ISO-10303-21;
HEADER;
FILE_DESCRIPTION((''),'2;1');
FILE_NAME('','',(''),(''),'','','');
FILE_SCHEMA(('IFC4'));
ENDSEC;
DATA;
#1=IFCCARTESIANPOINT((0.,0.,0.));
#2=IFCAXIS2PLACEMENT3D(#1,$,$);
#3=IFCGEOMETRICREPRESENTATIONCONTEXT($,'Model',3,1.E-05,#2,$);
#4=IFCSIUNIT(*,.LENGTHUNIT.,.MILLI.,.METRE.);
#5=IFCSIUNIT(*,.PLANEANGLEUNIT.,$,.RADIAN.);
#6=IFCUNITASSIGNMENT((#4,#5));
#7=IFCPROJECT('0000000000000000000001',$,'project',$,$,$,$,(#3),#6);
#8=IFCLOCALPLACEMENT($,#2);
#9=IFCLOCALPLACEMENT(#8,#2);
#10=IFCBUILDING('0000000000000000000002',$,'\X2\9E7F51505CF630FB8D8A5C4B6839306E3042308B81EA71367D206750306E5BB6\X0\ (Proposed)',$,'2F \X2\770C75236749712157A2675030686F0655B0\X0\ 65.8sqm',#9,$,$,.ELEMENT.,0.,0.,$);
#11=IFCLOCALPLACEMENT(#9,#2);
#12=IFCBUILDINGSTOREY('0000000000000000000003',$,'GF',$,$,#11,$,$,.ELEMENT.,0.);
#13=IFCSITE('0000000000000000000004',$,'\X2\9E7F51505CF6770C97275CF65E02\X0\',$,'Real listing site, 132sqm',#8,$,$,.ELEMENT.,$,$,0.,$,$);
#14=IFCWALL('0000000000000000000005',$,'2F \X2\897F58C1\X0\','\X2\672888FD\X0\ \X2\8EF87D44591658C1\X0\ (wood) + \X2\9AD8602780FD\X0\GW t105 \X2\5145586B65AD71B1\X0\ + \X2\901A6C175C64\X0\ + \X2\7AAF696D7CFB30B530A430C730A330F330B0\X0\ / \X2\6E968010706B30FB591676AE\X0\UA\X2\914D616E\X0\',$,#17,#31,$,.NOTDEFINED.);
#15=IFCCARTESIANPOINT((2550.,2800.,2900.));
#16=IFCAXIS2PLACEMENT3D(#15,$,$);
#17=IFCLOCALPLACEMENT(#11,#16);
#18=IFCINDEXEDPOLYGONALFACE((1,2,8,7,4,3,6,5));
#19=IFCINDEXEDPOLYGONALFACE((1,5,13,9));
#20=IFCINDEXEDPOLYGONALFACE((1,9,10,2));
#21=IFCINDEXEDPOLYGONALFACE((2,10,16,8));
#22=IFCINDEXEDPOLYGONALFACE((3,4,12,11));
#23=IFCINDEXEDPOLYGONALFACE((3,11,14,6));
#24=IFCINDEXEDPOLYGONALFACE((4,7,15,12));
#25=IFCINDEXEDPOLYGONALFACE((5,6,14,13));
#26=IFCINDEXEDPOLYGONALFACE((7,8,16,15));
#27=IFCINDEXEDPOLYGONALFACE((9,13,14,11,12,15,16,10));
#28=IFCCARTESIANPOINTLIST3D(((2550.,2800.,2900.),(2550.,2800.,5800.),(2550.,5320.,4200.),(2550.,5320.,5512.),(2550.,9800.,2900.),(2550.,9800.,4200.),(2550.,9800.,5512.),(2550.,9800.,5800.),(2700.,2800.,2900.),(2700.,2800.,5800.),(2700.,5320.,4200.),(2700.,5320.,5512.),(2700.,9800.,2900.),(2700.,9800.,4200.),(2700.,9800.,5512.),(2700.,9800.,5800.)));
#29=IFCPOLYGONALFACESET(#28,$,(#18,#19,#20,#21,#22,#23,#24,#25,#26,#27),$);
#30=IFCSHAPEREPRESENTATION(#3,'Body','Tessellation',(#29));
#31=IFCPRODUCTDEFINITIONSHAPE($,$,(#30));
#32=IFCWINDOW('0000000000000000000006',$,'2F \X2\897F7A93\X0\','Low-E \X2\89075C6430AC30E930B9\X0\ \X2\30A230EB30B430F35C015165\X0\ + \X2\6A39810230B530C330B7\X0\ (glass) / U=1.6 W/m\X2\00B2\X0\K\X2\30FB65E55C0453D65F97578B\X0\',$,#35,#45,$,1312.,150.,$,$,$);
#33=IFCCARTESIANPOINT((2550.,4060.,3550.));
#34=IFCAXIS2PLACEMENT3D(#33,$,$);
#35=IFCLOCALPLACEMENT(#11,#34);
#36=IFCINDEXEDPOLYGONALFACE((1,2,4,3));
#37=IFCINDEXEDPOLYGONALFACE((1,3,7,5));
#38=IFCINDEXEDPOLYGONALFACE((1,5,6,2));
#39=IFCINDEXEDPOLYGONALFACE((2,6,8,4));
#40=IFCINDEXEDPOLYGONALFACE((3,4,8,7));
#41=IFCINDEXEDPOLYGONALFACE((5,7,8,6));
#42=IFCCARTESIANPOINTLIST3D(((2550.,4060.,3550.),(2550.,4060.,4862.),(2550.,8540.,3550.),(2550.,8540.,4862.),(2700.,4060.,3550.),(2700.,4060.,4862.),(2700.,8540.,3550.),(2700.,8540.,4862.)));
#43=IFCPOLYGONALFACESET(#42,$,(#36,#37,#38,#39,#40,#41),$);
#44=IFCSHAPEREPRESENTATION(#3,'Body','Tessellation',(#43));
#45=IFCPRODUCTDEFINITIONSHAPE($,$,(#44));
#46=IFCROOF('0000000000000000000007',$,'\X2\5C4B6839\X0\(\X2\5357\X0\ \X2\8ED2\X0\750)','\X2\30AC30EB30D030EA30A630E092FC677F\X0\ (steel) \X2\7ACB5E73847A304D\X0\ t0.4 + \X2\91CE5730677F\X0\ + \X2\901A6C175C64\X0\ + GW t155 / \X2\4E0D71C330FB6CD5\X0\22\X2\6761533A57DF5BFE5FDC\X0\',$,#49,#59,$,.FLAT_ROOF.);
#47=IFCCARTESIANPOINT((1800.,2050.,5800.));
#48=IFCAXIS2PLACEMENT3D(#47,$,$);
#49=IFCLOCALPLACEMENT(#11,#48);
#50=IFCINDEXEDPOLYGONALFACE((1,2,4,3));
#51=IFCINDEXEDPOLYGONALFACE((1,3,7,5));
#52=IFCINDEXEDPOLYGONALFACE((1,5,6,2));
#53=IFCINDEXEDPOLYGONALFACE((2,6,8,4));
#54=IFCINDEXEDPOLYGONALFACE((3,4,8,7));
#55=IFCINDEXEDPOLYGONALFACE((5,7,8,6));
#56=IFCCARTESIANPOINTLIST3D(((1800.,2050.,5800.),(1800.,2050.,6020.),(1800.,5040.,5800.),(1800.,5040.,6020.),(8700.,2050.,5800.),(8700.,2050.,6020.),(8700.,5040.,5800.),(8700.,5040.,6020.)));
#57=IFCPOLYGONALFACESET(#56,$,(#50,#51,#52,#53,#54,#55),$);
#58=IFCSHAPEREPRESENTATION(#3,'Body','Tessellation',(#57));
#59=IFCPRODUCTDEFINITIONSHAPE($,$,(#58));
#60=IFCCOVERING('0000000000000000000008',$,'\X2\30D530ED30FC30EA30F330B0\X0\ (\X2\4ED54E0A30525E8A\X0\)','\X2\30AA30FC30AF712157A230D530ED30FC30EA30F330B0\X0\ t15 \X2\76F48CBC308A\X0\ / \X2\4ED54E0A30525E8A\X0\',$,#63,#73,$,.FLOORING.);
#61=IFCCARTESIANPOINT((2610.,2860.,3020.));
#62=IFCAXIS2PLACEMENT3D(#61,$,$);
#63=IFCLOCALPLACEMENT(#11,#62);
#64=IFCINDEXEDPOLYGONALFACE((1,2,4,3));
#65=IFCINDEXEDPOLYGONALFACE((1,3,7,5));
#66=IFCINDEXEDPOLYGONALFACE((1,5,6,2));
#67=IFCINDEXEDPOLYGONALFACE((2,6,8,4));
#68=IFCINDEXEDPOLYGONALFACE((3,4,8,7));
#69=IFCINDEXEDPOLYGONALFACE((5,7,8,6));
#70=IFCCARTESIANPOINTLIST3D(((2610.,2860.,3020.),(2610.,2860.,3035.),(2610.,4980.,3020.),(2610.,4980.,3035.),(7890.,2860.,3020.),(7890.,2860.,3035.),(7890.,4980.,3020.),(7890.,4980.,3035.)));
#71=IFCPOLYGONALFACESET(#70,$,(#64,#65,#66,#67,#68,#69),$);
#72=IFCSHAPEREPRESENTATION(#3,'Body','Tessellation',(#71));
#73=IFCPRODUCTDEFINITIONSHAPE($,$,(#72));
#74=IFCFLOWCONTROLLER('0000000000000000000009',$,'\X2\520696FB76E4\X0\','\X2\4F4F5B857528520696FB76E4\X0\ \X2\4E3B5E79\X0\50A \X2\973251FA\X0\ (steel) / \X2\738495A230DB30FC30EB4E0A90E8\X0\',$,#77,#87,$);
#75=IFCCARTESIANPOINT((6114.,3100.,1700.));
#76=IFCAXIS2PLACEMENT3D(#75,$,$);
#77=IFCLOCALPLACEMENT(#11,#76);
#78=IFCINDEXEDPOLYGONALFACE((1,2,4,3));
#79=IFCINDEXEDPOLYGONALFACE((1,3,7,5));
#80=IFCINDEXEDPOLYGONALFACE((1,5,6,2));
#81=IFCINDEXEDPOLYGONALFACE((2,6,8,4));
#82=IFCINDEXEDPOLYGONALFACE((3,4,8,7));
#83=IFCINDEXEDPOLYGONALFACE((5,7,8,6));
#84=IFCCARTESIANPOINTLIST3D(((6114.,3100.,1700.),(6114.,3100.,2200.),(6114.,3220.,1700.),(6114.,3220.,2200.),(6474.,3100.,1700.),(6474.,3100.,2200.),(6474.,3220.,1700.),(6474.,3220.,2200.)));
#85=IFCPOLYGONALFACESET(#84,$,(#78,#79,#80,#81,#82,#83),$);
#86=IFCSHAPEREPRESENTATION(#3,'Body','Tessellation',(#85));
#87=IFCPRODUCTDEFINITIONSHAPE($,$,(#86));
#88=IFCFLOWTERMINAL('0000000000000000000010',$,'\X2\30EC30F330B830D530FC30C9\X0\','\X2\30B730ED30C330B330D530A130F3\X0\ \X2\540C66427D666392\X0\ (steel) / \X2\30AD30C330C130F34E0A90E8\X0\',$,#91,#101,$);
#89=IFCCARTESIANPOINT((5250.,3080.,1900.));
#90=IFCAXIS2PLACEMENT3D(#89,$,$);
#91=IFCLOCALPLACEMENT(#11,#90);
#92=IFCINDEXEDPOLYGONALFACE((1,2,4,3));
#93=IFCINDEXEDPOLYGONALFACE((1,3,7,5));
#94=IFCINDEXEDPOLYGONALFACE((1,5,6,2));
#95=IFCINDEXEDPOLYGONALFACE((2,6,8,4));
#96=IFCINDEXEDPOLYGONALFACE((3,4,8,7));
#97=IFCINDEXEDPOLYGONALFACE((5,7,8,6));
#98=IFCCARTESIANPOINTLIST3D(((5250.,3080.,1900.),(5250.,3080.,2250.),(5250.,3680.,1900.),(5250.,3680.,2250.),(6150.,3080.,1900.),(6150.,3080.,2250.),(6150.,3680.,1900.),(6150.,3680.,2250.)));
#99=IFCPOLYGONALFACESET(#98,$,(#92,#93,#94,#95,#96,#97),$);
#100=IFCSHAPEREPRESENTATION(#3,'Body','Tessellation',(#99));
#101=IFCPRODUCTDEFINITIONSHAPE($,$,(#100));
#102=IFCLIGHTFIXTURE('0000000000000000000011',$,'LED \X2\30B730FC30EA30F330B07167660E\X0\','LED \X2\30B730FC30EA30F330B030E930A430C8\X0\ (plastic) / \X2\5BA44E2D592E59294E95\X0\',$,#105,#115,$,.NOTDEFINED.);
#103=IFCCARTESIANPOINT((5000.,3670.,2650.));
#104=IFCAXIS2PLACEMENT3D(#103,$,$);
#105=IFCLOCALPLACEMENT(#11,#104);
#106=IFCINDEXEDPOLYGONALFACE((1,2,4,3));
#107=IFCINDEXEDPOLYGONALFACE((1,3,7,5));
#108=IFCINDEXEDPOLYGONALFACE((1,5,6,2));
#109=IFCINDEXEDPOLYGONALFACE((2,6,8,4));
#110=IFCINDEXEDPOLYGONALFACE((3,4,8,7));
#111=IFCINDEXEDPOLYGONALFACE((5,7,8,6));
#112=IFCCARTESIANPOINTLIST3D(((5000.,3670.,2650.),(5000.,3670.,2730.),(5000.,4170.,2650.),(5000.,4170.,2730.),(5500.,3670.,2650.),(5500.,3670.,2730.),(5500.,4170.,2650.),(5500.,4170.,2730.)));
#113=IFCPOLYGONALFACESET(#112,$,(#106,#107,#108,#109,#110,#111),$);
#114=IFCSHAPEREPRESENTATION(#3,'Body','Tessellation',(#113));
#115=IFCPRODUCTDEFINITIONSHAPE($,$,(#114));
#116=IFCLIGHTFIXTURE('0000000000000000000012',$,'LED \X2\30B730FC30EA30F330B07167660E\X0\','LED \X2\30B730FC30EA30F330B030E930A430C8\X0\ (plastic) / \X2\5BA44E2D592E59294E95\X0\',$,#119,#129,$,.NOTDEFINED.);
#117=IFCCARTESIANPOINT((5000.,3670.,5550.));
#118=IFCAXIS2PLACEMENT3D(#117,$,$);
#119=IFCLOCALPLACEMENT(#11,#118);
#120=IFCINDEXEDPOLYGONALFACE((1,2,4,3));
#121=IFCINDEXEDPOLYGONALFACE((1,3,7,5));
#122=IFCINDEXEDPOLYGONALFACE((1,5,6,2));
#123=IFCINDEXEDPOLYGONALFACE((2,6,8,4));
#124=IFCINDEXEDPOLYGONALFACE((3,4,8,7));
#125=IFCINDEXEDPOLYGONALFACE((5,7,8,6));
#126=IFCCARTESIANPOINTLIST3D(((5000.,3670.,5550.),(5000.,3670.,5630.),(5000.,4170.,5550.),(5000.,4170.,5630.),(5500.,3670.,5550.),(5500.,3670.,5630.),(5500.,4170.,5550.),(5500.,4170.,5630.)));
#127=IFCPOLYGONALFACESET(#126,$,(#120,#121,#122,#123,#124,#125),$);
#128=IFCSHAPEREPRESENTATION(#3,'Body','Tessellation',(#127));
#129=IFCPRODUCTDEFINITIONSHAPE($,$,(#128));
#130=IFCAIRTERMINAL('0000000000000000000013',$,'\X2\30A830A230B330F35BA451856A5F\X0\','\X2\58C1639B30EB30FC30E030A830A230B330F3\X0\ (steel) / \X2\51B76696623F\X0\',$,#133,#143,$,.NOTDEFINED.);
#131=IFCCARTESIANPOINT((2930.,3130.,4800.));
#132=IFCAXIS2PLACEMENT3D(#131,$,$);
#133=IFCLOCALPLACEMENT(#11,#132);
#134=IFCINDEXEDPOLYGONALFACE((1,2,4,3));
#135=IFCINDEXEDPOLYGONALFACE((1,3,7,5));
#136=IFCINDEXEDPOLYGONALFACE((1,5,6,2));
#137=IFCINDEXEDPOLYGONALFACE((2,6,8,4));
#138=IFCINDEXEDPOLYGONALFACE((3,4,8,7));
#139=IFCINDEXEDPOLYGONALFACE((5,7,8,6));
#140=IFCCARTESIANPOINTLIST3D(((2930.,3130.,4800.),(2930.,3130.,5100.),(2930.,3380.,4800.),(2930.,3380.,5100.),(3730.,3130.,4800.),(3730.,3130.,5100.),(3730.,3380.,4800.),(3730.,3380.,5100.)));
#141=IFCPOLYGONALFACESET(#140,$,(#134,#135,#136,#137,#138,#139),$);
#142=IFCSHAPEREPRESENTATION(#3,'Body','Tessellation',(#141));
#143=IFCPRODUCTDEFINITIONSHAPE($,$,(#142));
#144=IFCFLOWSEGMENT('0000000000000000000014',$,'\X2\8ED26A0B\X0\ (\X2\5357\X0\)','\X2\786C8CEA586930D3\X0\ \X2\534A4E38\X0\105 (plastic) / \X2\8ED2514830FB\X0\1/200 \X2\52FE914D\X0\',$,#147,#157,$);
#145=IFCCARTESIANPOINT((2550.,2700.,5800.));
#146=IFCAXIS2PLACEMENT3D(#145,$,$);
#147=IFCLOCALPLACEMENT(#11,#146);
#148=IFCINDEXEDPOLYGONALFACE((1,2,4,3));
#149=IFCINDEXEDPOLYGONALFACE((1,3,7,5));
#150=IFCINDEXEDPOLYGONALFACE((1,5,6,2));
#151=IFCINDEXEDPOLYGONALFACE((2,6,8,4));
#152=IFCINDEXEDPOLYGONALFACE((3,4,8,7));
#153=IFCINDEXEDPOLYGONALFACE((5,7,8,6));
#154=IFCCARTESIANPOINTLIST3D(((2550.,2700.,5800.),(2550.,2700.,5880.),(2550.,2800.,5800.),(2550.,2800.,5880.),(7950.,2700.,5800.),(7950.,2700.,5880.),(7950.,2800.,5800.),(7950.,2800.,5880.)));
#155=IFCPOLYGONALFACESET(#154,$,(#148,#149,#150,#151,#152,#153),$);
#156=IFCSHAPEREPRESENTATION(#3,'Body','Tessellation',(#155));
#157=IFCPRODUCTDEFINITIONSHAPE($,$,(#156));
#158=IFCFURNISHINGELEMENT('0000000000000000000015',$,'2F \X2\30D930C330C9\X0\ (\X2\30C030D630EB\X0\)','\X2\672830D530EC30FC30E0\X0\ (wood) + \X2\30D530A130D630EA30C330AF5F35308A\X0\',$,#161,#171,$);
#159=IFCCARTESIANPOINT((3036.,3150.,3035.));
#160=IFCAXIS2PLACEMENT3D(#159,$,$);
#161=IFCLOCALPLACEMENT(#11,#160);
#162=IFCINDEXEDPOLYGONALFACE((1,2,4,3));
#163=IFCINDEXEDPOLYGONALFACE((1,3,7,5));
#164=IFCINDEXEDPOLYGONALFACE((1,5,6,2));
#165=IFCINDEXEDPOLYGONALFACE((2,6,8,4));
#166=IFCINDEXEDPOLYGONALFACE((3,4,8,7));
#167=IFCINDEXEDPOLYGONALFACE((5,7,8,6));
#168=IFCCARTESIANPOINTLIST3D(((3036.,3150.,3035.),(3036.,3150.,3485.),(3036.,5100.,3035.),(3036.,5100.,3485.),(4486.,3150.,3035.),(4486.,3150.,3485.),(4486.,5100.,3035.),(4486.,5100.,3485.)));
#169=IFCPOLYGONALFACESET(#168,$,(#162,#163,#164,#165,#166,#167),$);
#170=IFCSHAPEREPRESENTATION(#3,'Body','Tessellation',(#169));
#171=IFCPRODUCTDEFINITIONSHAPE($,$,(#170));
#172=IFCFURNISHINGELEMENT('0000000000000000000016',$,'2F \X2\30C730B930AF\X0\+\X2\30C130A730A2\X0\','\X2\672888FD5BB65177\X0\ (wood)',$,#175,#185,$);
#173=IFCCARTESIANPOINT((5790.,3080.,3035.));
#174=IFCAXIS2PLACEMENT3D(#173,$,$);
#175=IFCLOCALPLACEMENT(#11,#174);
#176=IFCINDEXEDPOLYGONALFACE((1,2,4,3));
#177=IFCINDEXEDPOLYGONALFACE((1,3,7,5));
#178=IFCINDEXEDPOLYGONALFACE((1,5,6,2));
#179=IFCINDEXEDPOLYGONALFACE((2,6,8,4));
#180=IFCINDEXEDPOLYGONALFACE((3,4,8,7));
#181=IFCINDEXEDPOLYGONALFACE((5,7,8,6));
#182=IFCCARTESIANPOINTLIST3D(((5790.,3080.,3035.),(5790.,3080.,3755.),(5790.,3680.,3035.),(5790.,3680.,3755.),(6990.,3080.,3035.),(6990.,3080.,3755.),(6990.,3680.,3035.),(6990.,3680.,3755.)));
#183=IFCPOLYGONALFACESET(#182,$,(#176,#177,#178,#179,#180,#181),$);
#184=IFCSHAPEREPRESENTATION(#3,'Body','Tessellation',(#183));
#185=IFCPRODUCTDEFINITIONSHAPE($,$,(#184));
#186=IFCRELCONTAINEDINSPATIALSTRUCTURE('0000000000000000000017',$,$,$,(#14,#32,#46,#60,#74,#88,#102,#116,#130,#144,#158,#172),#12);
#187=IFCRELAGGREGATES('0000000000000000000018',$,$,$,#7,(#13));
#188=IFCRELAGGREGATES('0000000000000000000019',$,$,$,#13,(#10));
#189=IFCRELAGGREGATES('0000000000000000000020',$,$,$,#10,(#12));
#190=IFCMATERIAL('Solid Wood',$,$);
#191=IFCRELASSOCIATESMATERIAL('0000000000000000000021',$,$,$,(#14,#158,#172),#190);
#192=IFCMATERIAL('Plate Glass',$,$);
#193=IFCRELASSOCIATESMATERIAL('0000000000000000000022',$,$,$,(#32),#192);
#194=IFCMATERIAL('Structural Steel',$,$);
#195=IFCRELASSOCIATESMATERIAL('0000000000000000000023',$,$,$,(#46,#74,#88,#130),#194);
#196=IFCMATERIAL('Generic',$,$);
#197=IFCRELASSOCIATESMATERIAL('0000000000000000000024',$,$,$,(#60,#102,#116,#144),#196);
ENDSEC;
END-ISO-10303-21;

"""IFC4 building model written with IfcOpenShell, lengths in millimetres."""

from ifc_helpers import new_model, si_unit, frame, frame_2d, origin, place, context, project, spatial, rectangle, extrude, material, element, fill, save


model = new_model("IFC4")

# Units and contexts
model_context = context("Model", 3, precision=1e-05, world=origin())
ifc_project = project(units=[si_unit("LENGTHUNIT", "METRE", prefix="MILLI"), si_unit("PLANEANGLEUNIT", "RADIAN")], contexts=[model_context])

# Site, building, storey
site_placement = place(None, origin())
site = spatial("IfcSite", under=ifc_project, at=site_placement, Name="鹿児島県霧島市", ObjectType="Real listing site, 132sqm", CompositionType="ELEMENT", RefElevation=0.0)
building_placement = place(site_placement, origin())
building = spatial("IfcBuilding", under=site, at=building_placement, Name="鹿児島・越屋根のある自然素材の家 (Proposed)", ObjectType="2F 県産杉無垢材と漆喰 65.8sqm", CompositionType="ELEMENT", ElevationOfRefHeight=0.0, ElevationOfTerrain=0.0)
storey_placement = place(building_placement, origin())
storey = spatial("IfcBuildingStorey", under=building, at=storey_placement, Name="GF", CompositionType="ELEMENT", Elevation=0.0)

# Shared definitions
ifc_material_1 = material(Name="Solid Wood")

# Wall, opening, window
ifc_material_2 = material(Name="Plate Glass")
wall_1_placement = place(storey_placement, frame((2550.0, 2800.0, 2900.0)))
wall_1 = element("IfcWall", 1, at=wall_1_placement, inside=storey, material=ifc_material_1, Name="2F 西壁", Description="木製 軸組外壁 (wood) + 高性能GW t105 充填断熱 + 通気層 + 窯業系サイディング / 準耐火・外皮UA配慮", PredefinedType="NOTDEFINED", context=model_context, shape_type="SweptSolid", body=[
    extrude(rectangle(XDim=150.0, YDim=7000.0, at=frame_2d((75.0, 3500.0))), frame((2550.0, 2800.0, 2900.0)), (0.0, 0.0, 1.0), 2900.0),
])
opening_1_placement = place(storey_placement, frame((2550.0, 4060.0, 3550.0)))
opening_1 = element("IfcOpeningElement", 2, at=opening_1_placement, cuts=wall_1, PredefinedType="NOTDEFINED", context=model_context, shape_type="SweptSolid", body=[
    extrude(rectangle(XDim=150.0, YDim=4480.0, at=frame_2d((75.0, 2240.0))), frame((2550.0, 4060.0, 3550.0)), (0.0, 0.0, 1.0), 1312.0),
])
window_1_placement = place(storey_placement, frame((2550.0, 4060.0, 3550.0)))
window_1 = element("IfcWindow", 3, at=window_1_placement, inside=storey, material=ifc_material_2, Name="2F 西窓", Description="Low-E 複層ガラス アルゴン封入 + 樹脂サッシ (glass) / U=1.6 W/m²K・日射取得型", OverallHeight=1312.0, OverallWidth=150.0, context=model_context, shape_type="SweptSolid", body=[
    extrude(rectangle(XDim=150.0, YDim=4480.0, at=frame_2d((75.0, 2240.0))), frame((2550.0, 4060.0, 3550.0)), (0.0, 0.0, 1.0), 1312.0),
])
fill(opening_1, window_1)

# Roof
ifc_material_3 = material(Name="Structural Steel")
for number, where, name in (
    (4, (1800.0, 2050.0, 5800.0), "屋根(南 軒750)"),
):
    element("IfcRoof", number, at=place(storey_placement, frame(where)), inside=storey, material=ifc_material_3, Name=name, Description="ガルバリウム鋼板 (steel) 立平葺き t0.4 + 野地板 + 通気層 + GW t155 / 不燃・法22条区域対応", PredefinedType="FLAT_ROOF", context=model_context, shape_type="SweptSolid", body=[
        extrude(rectangle(XDim=6900.0, YDim=2990.0, at=frame_2d((3450.0, 1495.0))), frame((1800.0, 2050.0, 5800.0)), (0.0, 0.0, 1.0), 220.0),
    ])

# Covering
ifc_material_4 = material(Name="Generic")
covering_placement = place(storey_placement, frame((2610.0, 2860.0, 3020.0)))
element("IfcCovering", 5, at=covering_placement, inside=storey, material=ifc_material_4, Name="フローリング (仕上げ床)", Description="オーク無垢フローリング t15 直貼り / 仕上げ床", PredefinedType="FLOORING", context=model_context, shape_type="SweptSolid", body=[
    extrude(rectangle(XDim=5280.0, YDim=2120.0, at=frame_2d((2640.0, 1060.0))), frame((2610.0, 2860.0, 3020.0)), (0.0, 0.0, 1.0), 15.0),
])

# Flow controller
flow_controller_placement = place(storey_placement, frame((6114.0, 3100.0, 1700.0)))
element("IfcFlowController", 6, at=flow_controller_placement, inside=storey, material=ifc_material_3, Name="分電盤", Description="住宅用分電盤 主幹50A 露出 (steel) / 玄関ホール上部", context=model_context, shape_type="SweptSolid", body=[
    extrude(rectangle(XDim=360.0, YDim=120.0, at=frame_2d((180.0, 60.0))), frame((6114.0, 3100.0, 1700.0)), (0.0, 0.0, 1.0), 500.0),
])

# Flow terminal
flow_terminal_placement = place(storey_placement, frame((5250.0, 3080.0, 1900.0)))
element("IfcFlowTerminal", 7, at=flow_terminal_placement, inside=storey, material=ifc_material_3, Name="レンジフード", Description="シロッコファン 同時給排 (steel) / キッチン上部", context=model_context, shape_type="SweptSolid", body=[
    extrude(rectangle(XDim=900.0, YDim=600.0, at=frame_2d((450.0, 300.0))), frame((5250.0, 3080.0, 1900.0)), (0.0, 0.0, 1.0), 350.0),
])

# Light fixtures
light_fixture_1_placement = place(storey_placement, frame((5000.0, 3670.0, 2650.0)))
element("IfcLightFixture", 8, at=light_fixture_1_placement, inside=storey, material=ifc_material_4, Name="LED シーリング照明", Description="LED シーリングライト (plastic) / 室中央天井", PredefinedType="NOTDEFINED", context=model_context, shape_type="SweptSolid", body=[
    extrude(rectangle(XDim=500.0, YDim=500.0, at=frame_2d((250.0, 250.0))), frame((5000.0, 3670.0, 2650.0)), (0.0, 0.0, 1.0), 80.0),
])
light_fixture_2_placement = place(storey_placement, frame((5000.0, 3670.0, 5550.0)))
element("IfcLightFixture", 9, at=light_fixture_2_placement, inside=storey, material=ifc_material_4, Name="LED シーリング照明", Description="LED シーリングライト (plastic) / 室中央天井", PredefinedType="NOTDEFINED", context=model_context, shape_type="SweptSolid", body=[
    extrude(rectangle(XDim=500.0, YDim=500.0, at=frame_2d((250.0, 250.0))), frame((5000.0, 3670.0, 5550.0)), (0.0, 0.0, 1.0), 80.0),
])

# Air terminal
air_terminal_placement = place(storey_placement, frame((2930.0, 3130.0, 4800.0)))
element("IfcAirTerminal", 10, at=air_terminal_placement, inside=storey, material=ifc_material_3, Name="エアコン室内機", Description="壁掛ルームエアコン (steel) / 冷暖房", PredefinedType="NOTDEFINED", context=model_context, shape_type="SweptSolid", body=[
    extrude(rectangle(XDim=800.0, YDim=250.0, at=frame_2d((400.0, 125.0))), frame((2930.0, 3130.0, 4800.0)), (0.0, 0.0, 1.0), 300.0),
])

# Flow segment
flow_segment_placement = place(storey_placement, frame((2550.0, 2700.0, 5800.0)))
element("IfcFlowSegment", 11, at=flow_segment_placement, inside=storey, material=ifc_material_4, Name="軒樋 (南)", Description="硬質塩ビ 半丸105 (plastic) / 軒先・1/200 勾配", context=model_context, shape_type="SweptSolid", body=[
    extrude(rectangle(XDim=5400.0, YDim=100.0, at=frame_2d((2700.0, 50.0))), frame((2550.0, 2700.0, 5800.0)), (0.0, 0.0, 1.0), 80.0),
])

# Furnishing elements
furnishing_1_placement = place(storey_placement, frame((3036.0, 3150.0, 3035.0)))
element("IfcFurnishingElement", 12, at=furnishing_1_placement, inside=storey, material=ifc_material_1, Name="2F ベッド (ダブル)", Description="木フレーム (wood) + ファブリック張り", context=model_context, shape_type="SweptSolid", body=[
    extrude(rectangle(XDim=1450.0, YDim=1950.0, at=frame_2d((725.0, 975.0))), frame((3036.0, 3150.0, 3035.0)), (0.0, 0.0, 1.0), 450.0),
])
furnishing_2_placement = place(storey_placement, frame((5790.0, 3080.0, 3035.0)))
element("IfcFurnishingElement", 13, at=furnishing_2_placement, inside=storey, material=ifc_material_1, Name="2F デスク+チェア", Description="木製家具 (wood)", context=model_context, shape_type="SweptSolid", body=[
    extrude(rectangle(XDim=1200.0, YDim=600.0, at=frame_2d((600.0, 300.0))), frame((5790.0, 3080.0, 3035.0)), (0.0, 0.0, 1.0), 720.0),
])

save(model, "model.ifc")
